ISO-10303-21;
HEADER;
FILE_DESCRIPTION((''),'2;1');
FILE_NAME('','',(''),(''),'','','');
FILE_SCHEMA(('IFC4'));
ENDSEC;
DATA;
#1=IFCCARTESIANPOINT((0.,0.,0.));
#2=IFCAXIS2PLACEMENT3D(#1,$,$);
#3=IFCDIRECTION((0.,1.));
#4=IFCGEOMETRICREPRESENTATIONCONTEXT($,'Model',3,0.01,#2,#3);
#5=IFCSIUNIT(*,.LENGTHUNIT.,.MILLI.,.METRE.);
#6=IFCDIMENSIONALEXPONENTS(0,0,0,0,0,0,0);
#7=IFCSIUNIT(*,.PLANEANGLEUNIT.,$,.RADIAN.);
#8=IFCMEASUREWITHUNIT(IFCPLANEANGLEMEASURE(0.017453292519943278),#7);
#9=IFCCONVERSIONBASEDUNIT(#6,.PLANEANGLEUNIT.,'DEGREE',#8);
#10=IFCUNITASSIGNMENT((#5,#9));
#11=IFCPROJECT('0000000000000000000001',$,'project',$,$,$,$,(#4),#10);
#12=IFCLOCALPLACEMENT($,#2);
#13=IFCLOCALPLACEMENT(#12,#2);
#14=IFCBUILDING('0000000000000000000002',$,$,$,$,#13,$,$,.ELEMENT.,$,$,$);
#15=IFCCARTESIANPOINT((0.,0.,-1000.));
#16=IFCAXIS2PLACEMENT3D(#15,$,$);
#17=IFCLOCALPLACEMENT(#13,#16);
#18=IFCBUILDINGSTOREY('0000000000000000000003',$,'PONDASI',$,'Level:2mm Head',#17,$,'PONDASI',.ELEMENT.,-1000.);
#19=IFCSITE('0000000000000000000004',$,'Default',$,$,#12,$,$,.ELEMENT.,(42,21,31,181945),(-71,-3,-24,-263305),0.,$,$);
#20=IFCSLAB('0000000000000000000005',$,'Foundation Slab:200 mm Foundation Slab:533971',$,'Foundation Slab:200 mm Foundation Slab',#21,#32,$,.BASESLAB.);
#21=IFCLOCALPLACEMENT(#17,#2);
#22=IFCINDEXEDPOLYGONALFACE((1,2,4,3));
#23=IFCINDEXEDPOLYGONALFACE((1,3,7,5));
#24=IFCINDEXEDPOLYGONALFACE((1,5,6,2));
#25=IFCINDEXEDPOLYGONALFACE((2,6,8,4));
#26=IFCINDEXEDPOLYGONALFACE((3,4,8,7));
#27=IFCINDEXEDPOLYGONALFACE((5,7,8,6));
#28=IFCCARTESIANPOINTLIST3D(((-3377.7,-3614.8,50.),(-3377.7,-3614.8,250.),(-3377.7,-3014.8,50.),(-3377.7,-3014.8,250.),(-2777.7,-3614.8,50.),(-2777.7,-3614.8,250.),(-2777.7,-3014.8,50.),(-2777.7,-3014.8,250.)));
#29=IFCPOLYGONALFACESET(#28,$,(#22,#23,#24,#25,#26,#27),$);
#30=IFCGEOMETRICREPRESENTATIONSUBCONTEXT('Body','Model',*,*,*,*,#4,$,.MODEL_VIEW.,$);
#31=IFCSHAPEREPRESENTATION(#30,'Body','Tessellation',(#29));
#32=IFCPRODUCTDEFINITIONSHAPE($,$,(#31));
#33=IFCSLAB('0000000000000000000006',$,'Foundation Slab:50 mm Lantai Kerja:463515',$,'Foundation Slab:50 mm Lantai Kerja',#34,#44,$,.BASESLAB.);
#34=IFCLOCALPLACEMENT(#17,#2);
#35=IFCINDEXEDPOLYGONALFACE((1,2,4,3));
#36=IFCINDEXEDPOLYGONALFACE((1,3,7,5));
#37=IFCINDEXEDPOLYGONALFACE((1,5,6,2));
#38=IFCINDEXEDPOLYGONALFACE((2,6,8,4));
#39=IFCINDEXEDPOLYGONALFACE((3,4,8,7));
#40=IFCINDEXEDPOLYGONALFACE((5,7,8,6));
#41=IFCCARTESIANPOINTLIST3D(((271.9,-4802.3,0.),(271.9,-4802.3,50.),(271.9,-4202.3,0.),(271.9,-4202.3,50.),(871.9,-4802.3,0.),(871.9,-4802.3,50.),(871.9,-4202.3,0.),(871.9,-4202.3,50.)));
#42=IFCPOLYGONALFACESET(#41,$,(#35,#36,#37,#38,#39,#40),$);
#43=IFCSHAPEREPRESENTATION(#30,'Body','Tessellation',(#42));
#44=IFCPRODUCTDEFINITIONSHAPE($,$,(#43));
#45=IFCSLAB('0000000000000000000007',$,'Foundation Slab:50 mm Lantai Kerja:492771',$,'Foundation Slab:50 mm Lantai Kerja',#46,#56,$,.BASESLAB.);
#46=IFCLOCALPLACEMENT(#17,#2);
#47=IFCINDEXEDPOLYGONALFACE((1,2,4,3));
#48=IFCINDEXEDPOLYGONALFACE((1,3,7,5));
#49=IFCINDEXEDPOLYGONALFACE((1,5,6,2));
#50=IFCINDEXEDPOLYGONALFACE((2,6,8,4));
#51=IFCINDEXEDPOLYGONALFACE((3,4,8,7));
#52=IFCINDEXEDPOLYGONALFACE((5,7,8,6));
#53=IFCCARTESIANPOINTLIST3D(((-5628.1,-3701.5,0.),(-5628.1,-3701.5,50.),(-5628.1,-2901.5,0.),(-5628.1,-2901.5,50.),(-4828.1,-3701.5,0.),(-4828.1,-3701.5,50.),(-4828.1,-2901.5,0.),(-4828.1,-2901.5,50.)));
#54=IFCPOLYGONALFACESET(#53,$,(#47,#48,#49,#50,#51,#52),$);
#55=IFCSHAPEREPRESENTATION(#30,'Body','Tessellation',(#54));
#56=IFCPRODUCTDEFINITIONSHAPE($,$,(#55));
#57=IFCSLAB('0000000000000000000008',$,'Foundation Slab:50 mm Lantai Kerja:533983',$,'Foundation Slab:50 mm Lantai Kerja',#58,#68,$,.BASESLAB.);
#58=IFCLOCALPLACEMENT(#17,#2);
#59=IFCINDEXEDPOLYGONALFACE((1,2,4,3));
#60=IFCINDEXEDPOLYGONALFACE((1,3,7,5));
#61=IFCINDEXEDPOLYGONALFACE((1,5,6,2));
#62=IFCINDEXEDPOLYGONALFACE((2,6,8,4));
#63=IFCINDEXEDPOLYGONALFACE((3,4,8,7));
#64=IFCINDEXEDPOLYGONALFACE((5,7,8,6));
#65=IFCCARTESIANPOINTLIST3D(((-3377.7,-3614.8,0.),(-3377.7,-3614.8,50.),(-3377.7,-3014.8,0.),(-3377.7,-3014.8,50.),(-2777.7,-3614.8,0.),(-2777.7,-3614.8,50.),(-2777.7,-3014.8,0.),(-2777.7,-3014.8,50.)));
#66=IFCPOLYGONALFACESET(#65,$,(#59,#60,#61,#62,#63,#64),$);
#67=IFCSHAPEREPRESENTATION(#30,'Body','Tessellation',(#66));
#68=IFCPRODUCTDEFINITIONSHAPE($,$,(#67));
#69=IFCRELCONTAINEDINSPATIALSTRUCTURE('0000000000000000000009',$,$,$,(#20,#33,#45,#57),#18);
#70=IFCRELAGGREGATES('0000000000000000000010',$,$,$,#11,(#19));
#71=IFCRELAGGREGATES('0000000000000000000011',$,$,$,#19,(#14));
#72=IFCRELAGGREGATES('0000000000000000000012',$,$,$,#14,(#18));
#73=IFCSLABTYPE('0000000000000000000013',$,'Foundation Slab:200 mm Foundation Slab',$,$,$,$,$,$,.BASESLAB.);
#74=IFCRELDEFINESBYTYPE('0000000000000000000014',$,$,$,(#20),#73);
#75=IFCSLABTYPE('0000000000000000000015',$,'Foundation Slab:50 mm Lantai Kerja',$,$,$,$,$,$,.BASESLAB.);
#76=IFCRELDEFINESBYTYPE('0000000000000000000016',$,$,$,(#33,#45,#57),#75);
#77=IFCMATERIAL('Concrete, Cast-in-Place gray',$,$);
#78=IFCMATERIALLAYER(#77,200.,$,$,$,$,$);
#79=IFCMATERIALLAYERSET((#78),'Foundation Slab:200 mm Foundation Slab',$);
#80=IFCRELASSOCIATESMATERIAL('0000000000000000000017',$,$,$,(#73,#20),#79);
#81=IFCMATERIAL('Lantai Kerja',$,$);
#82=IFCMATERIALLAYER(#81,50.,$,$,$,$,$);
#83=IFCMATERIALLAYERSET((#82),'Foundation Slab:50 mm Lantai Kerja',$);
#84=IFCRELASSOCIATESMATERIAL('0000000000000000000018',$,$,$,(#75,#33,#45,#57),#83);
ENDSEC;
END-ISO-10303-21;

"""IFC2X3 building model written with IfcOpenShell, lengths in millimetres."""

from ifc_helpers import new_model, entity, si_unit, converted_unit, direction, frame, origin, origin_2d_with_axis, place, context, subcontext, project, spatial, rectangle, extrude, material, layer, layer_set, layer_usage, type_object, element, save


model = new_model("IFC2X3")

# Units and contexts
model_context = context("Model", 3, precision=0.01, world=origin(), true_north=direction((0.0, 1.0)))
body_context = subcontext(model_context, "Body", "Model", "MODEL_VIEW")
ifc_project = project(units=[si_unit("LENGTHUNIT", "METRE", prefix="MILLI"), converted_unit("PLANEANGLEUNIT", "DEGREE", entity("IfcPlaneAngleMeasure", 0.017453292519943278), si_unit("PLANEANGLEUNIT", "RADIAN"), dimensions=[0, 0, 0, 0, 0, 0, 0])], contexts=[model_context])

# Site, building, storey
site_placement = place(None, origin())
site = spatial("IfcSite", under=ifc_project, at=site_placement, Name="Default", CompositionType="ELEMENT", RefLatitude=(42, 21, 31, 181945), RefLongitude=(-71, -3, -24, -263305), RefElevation=0.0)
building_placement = place(site_placement, origin())
building = spatial("IfcBuilding", under=site, at=building_placement, CompositionType="ELEMENT")
storey_placement = place(building_placement, frame((0.0, 0.0, -1000.0)))
storey = spatial("IfcBuildingStorey", under=building, at=storey_placement, Name="PONDASI", ObjectType="Level:2mm Head", LongName="PONDASI", CompositionType="ELEMENT", Elevation=-1000.0)

# Shared definitions
ifc_material_1 = material(Name="Concrete, Cast-in-Place gray")

# Slabs
ifc_layer_1 = layer(ifc_material_1, 200.0)
ifc_layer_set_1 = layer_set([ifc_layer_1], Name="Foundation Slab:200 mm Foundation Slab")
ifc_layer_usage_1 = layer_usage(ifc_layer_set_1, "AXIS3", "POSITIVE", 0.0)
slab_type_1 = type_object("IfcSlabType", Name="Foundation Slab:200 mm Foundation Slab", PredefinedType="BASESLAB", material=ifc_layer_set_1)
slab_1_placement = place(storey_placement, origin())
element("IfcSlab", 1, at=slab_1_placement, inside=storey, type_object=slab_type_1, material=ifc_layer_usage_1, Name="Foundation Slab:200 mm Foundation Slab:533971", ObjectType="Foundation Slab:200 mm Foundation Slab", PredefinedType="BASESLAB", context=body_context, shape_type="SweptSolid", body=[
    extrude(rectangle(XDim=600.0, YDim=600.0, at=origin_2d_with_axis()), frame((-3077.7, -3314.8, 250.0), z_axis=(0.0, 0.0, -1.0), x_axis=(0.0, 1.0, 0.0)), (0.0, 0.0, 1.0), 200.0),
])
ifc_material_2 = material(Name="Lantai Kerja")
ifc_layer_2 = layer(ifc_material_2, 50.0)
ifc_layer_set_2 = layer_set([ifc_layer_2], Name="Foundation Slab:50 mm Lantai Kerja")
ifc_layer_usage_2 = layer_usage(ifc_layer_set_2, "AXIS3", "POSITIVE", 0.0)
slab_type_2 = type_object("IfcSlabType", Name="Foundation Slab:50 mm Lantai Kerja", PredefinedType="BASESLAB", material=ifc_layer_set_2)
slab_2_placement = place(storey_placement, origin())
element("IfcSlab", 2, at=slab_2_placement, inside=storey, type_object=slab_type_2, material=ifc_layer_usage_2, Name="Foundation Slab:50 mm Lantai Kerja:463515", ObjectType="Foundation Slab:50 mm Lantai Kerja", PredefinedType="BASESLAB", context=body_context, shape_type="SweptSolid", body=[
    extrude(rectangle(XDim=600.0, YDim=600.0, at=origin_2d_with_axis()), frame((571.9, -4502.3, 50.0), z_axis=(0.0, 0.0, -1.0), x_axis=(0.0, 1.0, 0.0)), (0.0, 0.0, 1.0), 50.0),
])
ifc_layer_usage_3 = layer_usage(ifc_layer_set_2, "AXIS3", "POSITIVE", 0.0)
slab_3_placement = place(storey_placement, origin())
element("IfcSlab", 3, at=slab_3_placement, inside=storey, type_object=slab_type_2, material=ifc_layer_usage_3, Name="Foundation Slab:50 mm Lantai Kerja:492771", ObjectType="Foundation Slab:50 mm Lantai Kerja", PredefinedType="BASESLAB", context=body_context, shape_type="SweptSolid", body=[
    extrude(rectangle(XDim=800.0, YDim=800.0, at=origin_2d_with_axis()), frame((-5228.1, -3301.5, 50.0), z_axis=(0.0, 0.0, -1.0), x_axis=(0.0, 1.0, 0.0)), (0.0, 0.0, 1.0), 50.0),
])
ifc_layer_usage_4 = layer_usage(ifc_layer_set_2, "AXIS3", "POSITIVE", 0.0)
slab_4_placement = place(storey_placement, origin())
element("IfcSlab", 4, at=slab_4_placement, inside=storey, type_object=slab_type_2, material=ifc_layer_usage_4, Name="Foundation Slab:50 mm Lantai Kerja:533983", ObjectType="Foundation Slab:50 mm Lantai Kerja", PredefinedType="BASESLAB", context=body_context, shape_type="SweptSolid", body=[
    extrude(rectangle(XDim=600.0, YDim=600.0, at=origin_2d_with_axis()), frame((-3077.7, -3314.8, 50.0), z_axis=(0.0, 0.0, -1.0), x_axis=(0.0, 1.0, 0.0)), (0.0, 0.0, 1.0), 50.0),
])

save(model, "model.ifc")
